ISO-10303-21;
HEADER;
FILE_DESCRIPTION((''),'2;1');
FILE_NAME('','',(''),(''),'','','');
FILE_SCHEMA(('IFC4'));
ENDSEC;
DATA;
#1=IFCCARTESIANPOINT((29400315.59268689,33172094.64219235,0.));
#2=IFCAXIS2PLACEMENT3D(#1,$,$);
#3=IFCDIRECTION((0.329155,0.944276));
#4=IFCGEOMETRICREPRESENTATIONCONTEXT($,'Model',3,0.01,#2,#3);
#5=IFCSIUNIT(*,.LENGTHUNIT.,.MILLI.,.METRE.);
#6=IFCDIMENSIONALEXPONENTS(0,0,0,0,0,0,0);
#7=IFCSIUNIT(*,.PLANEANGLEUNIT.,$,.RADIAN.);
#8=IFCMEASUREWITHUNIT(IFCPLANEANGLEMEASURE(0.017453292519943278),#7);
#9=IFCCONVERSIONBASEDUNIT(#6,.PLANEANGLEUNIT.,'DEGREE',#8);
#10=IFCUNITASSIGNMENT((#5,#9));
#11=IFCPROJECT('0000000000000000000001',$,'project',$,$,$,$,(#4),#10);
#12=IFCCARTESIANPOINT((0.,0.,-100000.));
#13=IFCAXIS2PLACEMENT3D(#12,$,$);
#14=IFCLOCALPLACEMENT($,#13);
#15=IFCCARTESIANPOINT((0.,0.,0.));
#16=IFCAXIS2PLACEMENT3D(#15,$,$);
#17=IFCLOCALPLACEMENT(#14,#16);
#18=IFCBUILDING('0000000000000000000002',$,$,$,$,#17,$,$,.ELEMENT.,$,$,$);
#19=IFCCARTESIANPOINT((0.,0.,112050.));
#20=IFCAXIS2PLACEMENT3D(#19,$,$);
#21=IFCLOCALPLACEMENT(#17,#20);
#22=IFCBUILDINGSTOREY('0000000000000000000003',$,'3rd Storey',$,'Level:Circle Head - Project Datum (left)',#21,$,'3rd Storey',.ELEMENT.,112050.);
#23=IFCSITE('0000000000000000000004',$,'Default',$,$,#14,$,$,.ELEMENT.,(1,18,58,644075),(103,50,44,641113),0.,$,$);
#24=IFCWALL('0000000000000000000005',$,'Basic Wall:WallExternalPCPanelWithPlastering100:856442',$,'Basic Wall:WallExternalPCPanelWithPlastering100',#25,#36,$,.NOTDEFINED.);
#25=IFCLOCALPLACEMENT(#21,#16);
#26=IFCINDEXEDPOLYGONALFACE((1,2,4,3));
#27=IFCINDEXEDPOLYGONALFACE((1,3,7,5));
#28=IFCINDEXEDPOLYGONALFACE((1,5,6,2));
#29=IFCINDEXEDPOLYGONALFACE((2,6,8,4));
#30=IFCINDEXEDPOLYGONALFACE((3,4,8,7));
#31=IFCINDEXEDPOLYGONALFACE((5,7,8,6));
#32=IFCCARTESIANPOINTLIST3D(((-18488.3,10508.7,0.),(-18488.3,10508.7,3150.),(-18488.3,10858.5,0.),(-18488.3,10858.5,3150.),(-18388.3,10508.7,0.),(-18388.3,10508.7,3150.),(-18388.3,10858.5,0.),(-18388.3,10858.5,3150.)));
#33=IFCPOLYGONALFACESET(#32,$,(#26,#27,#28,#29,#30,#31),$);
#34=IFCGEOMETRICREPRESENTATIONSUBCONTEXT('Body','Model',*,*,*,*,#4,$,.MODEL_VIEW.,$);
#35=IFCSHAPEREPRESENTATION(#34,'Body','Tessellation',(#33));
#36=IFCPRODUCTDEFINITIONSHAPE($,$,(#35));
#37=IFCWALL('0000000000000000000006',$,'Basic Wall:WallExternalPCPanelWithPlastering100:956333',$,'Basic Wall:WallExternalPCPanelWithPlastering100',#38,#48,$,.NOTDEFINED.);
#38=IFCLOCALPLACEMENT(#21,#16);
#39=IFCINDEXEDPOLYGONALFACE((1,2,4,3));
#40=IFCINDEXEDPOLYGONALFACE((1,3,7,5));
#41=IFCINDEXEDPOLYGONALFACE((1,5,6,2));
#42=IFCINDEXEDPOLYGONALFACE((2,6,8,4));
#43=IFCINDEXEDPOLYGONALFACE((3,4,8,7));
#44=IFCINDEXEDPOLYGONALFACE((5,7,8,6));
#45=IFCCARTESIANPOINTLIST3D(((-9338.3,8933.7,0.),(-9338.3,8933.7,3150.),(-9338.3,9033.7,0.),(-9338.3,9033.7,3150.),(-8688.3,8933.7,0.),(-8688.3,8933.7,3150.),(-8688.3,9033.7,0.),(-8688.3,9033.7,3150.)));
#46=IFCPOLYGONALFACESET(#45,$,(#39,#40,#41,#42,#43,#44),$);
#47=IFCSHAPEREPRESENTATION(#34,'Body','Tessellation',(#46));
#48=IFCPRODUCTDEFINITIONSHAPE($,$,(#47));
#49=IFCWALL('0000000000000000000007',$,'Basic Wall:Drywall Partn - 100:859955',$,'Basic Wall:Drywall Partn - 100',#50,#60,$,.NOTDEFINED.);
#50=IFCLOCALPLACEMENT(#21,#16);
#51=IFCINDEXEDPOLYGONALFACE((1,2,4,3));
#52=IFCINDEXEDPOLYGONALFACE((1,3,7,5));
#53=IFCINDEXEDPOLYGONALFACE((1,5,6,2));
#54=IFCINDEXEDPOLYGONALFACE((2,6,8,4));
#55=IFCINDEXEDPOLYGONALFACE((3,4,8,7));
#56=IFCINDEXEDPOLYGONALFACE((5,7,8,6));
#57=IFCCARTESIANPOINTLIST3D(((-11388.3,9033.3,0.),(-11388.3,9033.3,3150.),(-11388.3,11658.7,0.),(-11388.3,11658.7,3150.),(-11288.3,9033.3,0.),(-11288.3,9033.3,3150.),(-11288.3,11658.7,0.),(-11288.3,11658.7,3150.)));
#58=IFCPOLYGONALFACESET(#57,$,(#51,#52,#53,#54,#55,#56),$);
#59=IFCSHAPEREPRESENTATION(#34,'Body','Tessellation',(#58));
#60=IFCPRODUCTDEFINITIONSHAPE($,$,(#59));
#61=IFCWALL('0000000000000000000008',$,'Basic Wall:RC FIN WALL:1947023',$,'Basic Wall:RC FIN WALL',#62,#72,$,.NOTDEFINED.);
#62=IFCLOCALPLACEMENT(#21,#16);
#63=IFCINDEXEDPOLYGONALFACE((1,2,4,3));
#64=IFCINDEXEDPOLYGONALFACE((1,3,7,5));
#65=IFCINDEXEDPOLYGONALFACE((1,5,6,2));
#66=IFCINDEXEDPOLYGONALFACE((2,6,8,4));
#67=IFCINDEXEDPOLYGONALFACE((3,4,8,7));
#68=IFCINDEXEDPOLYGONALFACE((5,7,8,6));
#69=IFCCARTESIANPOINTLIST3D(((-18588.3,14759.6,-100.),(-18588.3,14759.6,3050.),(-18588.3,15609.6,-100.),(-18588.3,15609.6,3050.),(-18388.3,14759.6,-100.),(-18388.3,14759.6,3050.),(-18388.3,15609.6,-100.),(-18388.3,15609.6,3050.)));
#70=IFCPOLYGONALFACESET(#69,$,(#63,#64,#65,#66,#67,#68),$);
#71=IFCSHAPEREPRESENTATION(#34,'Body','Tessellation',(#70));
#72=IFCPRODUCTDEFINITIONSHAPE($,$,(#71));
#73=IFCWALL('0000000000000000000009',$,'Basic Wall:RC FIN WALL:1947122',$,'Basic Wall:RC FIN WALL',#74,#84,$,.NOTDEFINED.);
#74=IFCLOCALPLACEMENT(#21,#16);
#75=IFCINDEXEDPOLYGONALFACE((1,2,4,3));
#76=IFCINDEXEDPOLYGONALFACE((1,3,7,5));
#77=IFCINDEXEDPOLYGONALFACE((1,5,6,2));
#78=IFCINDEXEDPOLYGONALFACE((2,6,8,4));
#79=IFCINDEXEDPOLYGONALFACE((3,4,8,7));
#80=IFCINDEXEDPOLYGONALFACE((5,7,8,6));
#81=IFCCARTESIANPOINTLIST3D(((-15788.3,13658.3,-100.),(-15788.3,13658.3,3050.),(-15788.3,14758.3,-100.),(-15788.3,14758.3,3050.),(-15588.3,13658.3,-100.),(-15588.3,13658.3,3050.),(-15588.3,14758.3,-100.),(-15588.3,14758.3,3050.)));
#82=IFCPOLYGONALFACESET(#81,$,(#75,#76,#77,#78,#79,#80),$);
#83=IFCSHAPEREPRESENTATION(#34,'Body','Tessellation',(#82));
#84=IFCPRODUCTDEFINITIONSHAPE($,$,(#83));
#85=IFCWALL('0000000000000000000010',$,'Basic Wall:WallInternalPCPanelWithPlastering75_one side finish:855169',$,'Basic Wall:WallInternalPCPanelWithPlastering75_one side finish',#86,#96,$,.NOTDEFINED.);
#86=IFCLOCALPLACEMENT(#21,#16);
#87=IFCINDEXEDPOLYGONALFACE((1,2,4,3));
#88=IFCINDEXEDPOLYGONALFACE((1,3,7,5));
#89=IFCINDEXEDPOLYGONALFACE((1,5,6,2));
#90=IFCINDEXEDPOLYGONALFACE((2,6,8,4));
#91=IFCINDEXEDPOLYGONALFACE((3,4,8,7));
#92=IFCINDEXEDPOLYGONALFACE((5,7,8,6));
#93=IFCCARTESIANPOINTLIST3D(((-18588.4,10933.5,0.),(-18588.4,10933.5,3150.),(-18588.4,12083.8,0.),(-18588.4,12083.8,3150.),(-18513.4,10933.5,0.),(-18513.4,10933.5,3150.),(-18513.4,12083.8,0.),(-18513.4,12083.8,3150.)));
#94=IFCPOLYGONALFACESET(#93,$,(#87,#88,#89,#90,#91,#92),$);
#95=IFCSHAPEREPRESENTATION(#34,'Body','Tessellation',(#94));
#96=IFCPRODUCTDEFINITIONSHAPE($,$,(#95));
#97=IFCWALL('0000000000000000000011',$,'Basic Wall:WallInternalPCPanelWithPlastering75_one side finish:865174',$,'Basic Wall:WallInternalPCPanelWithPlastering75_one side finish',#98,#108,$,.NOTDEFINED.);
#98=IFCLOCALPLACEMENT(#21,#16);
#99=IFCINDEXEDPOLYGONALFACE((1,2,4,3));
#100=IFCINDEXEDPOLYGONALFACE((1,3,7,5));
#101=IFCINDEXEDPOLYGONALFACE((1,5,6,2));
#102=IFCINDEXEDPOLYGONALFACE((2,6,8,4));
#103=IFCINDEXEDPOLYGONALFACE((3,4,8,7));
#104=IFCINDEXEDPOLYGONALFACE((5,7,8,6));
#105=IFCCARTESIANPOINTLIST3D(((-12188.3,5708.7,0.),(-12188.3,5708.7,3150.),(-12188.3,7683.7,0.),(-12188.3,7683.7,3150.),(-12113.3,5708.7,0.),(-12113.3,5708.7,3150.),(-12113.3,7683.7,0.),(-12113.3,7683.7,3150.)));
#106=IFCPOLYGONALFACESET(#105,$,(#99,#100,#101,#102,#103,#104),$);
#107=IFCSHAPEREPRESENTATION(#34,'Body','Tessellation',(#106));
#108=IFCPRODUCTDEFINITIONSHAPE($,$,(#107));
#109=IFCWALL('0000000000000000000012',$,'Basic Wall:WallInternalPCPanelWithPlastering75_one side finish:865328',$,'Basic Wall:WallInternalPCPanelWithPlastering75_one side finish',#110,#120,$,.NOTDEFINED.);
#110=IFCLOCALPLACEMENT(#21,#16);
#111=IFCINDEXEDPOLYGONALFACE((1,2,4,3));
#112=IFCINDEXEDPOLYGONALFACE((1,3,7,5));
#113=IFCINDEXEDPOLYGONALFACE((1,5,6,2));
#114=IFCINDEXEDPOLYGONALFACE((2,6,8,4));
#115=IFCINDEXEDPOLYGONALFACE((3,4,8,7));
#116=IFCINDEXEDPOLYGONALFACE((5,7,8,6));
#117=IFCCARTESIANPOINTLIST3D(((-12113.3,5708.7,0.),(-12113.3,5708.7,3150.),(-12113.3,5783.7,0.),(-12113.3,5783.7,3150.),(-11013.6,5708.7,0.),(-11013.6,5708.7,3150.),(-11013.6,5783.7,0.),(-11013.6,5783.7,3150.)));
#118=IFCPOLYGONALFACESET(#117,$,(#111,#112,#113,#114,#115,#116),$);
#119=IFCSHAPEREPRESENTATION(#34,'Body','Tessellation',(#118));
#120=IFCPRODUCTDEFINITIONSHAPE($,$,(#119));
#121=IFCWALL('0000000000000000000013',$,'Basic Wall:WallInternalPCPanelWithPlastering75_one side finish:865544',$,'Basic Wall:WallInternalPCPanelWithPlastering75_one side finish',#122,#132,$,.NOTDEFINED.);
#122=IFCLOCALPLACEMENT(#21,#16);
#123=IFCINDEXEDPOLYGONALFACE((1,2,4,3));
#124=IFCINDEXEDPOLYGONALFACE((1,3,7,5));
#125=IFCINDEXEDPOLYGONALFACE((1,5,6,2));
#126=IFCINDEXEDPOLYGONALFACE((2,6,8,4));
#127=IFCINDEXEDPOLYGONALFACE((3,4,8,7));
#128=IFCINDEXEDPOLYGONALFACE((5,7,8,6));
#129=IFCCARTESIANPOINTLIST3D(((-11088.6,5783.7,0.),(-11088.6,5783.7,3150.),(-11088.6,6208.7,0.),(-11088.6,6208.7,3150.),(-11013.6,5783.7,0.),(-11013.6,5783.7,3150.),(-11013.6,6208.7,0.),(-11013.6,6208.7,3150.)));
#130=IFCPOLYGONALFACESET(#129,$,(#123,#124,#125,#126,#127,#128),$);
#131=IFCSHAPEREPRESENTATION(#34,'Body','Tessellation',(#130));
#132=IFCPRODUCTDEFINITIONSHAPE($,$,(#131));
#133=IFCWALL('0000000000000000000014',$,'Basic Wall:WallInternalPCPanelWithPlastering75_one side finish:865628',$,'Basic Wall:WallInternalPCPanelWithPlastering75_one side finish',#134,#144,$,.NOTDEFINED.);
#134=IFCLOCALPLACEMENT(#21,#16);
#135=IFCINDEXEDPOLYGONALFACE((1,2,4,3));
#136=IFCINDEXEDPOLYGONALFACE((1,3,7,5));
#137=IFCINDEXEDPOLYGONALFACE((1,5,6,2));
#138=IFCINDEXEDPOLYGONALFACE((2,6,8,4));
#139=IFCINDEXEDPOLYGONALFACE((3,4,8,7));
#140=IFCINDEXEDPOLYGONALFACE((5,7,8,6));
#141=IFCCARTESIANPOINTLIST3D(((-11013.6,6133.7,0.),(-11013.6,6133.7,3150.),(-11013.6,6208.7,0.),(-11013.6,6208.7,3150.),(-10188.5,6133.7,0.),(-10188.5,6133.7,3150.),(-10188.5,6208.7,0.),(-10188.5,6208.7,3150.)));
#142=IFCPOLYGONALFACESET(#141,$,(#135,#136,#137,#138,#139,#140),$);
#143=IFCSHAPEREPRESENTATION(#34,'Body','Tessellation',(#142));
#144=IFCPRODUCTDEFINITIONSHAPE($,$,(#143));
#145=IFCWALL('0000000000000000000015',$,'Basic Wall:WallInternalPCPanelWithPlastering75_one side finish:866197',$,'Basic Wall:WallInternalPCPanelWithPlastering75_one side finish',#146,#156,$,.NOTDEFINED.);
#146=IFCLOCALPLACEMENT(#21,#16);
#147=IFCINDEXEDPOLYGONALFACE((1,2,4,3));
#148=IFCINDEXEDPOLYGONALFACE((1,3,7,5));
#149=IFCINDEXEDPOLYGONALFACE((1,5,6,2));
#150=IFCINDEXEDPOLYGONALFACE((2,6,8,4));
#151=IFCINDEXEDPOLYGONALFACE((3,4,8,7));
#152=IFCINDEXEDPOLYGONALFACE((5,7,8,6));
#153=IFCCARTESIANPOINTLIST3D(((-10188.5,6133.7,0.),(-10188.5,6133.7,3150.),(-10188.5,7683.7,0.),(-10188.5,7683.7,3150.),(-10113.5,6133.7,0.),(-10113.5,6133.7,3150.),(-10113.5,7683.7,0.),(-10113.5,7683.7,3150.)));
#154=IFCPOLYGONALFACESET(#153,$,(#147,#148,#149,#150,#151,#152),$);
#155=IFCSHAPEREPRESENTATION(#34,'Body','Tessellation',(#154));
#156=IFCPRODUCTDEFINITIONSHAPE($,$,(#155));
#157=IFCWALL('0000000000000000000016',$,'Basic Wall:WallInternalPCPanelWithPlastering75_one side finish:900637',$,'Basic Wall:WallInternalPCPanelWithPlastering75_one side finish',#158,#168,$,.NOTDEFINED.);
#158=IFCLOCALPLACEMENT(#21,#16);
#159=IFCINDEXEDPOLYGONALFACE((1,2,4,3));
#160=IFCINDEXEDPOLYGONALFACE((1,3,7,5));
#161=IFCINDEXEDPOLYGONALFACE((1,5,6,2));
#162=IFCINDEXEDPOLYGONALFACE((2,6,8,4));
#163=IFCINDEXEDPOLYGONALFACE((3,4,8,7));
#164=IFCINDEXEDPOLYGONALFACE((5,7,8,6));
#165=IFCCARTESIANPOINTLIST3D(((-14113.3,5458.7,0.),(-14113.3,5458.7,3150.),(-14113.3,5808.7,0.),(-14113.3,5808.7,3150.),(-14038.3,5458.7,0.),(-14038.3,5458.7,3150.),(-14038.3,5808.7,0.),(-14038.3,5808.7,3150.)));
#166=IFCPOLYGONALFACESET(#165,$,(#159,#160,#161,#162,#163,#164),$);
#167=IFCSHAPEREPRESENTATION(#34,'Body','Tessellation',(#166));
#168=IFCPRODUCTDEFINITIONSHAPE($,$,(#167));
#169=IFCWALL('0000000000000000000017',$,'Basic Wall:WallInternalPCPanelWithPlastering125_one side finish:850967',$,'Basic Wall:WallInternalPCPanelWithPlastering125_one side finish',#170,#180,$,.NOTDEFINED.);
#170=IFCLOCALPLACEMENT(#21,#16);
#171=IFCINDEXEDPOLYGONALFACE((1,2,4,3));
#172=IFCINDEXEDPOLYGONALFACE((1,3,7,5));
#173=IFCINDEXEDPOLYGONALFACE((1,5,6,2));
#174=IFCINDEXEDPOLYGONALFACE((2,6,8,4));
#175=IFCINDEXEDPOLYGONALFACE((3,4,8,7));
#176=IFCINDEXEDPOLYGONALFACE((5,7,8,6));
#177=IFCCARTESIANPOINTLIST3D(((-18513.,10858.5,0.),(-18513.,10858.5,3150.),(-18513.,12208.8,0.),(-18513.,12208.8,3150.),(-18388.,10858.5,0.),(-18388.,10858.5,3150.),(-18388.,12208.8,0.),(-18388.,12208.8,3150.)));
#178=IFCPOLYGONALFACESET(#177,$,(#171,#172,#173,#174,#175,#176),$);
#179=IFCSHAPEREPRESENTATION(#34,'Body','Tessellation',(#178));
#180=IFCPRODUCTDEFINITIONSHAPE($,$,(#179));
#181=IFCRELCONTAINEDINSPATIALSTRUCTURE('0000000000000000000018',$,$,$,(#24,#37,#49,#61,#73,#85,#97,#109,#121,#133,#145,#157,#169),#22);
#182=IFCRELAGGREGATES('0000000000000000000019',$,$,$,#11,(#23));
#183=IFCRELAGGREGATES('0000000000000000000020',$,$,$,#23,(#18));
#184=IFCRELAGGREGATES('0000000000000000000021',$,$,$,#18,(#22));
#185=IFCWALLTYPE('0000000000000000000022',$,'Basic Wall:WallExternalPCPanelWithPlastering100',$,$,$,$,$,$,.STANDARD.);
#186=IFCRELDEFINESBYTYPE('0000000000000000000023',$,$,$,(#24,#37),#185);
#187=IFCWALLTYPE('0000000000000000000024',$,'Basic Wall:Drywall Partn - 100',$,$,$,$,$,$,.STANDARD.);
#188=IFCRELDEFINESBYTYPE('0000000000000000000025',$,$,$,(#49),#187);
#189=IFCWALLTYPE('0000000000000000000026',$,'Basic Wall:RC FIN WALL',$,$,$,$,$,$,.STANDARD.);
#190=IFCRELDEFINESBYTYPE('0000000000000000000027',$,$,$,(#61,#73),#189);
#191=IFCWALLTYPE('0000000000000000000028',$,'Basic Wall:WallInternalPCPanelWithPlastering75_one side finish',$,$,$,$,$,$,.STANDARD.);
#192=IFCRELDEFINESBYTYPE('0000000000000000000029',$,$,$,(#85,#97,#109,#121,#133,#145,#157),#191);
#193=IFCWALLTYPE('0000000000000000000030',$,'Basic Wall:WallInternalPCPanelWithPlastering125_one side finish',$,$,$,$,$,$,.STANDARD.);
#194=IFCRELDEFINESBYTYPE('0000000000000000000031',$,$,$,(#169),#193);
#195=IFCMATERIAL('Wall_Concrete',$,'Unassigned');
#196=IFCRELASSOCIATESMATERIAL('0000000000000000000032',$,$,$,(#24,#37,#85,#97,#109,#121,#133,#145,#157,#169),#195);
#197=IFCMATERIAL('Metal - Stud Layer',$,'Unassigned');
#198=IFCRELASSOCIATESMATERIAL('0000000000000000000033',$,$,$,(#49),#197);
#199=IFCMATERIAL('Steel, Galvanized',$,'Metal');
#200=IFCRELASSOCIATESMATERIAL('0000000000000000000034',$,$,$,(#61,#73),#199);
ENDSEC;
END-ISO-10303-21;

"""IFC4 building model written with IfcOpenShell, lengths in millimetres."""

from ifc_helpers import new_model, entity, si_unit, converted_unit, direction, frame, origin, place, context, subcontext, project, spatial, indexed_curve, outline, extrude, material, type_object, element, save


model = new_model("IFC4")

# Units and contexts
model_context = context("Model", 3, precision=0.01, world=frame((29400315.59268689, 33172094.64219235, 0.0)), true_north=direction((0.329155, 0.944276)))
body_context = subcontext(model_context, "Body", "Model", "MODEL_VIEW")
ifc_project = project(units=[si_unit("LENGTHUNIT", "METRE", prefix="MILLI"), converted_unit("PLANEANGLEUNIT", "DEGREE", entity("IfcPlaneAngleMeasure", 0.017453292519943278), si_unit("PLANEANGLEUNIT", "RADIAN"), dimensions=[0, 0, 0, 0, 0, 0, 0])], contexts=[model_context])

# Site, building, storey
site_placement = place(None, frame((0.0, 0.0, -100000.0)))
site = spatial("IfcSite", under=ifc_project, at=site_placement, Name="Default", CompositionType="ELEMENT", RefLatitude=(1, 18, 58, 644075), RefLongitude=(103, 50, 44, 641113), RefElevation=0.0)
building_placement = place(site_placement, origin())
building = spatial("IfcBuilding", under=site, at=building_placement, CompositionType="ELEMENT")
storey_placement = place(building_placement, frame((0.0, 0.0, 112050.0)))
storey = spatial("IfcBuildingStorey", under=building, at=storey_placement, Name="3rd Storey", ObjectType="Level:Circle Head - Project Datum (left)", LongName="3rd Storey", CompositionType="ELEMENT", Elevation=112050.0)

# Walls
ifc_material_1 = material(Name="Wall_Concrete", Category="Unassigned")
wall_type_1 = type_object("IfcWallType", Name="Basic Wall:WallExternalPCPanelWithPlastering100", PredefinedType="STANDARD")
wall_1_placement = place(storey_placement, frame((-18438.3, 10858.5, 0.0), z_axis=(0.0, 0.0, 1.0), x_axis=(0.0, -1.0, 0.0)))
element("IfcWall", 1, at=wall_1_placement, inside=storey, type_object=wall_type_1, material=ifc_material_1, Name="Basic Wall:WallExternalPCPanelWithPlastering100:856442", ObjectType="Basic Wall:WallExternalPCPanelWithPlastering100", PredefinedType="NOTDEFINED", context=body_context, shape_type="SweptSolid", body=[
    extrude(outline(indexed_curve([(349.8, 50.0), (0.0, 50.0), (0.0, -50.0), (349.8, -50.0), (349.8, 50.0)], self_intersect=False)), origin(), (0.0, 0.0, 1.0), 3150.0),
])
wall_2_placement = place(storey_placement, frame((-8688.3, 8983.7, 0.0), z_axis=(0.0, 0.0, 1.0), x_axis=(-1.0, 0.0, 0.0)))
element("IfcWall", 2, at=wall_2_placement, inside=storey, type_object=wall_type_1, material=ifc_material_1, Name="Basic Wall:WallExternalPCPanelWithPlastering100:956333", ObjectType="Basic Wall:WallExternalPCPanelWithPlastering100", PredefinedType="NOTDEFINED", context=body_context, shape_type="SweptSolid", body=[
    extrude(outline(indexed_curve([(650.0, 50.0), (0.0, 50.0), (0.0, -50.0), (650.0, -50.0), (650.0, 50.0)], self_intersect=False)), origin(), (0.0, 0.0, 1.0), 3150.0),
])
ifc_material_2 = material(Name="Metal - Stud Layer", Category="Unassigned")
wall_type_2 = type_object("IfcWallType", Name="Basic Wall:Drywall Partn - 100", PredefinedType="STANDARD")
wall_3_placement = place(storey_placement, frame((-11338.3, 11658.7, 0.0), z_axis=(0.0, 0.0, 1.0), x_axis=(0.0, -1.0, 0.0)))
element("IfcWall", 3, at=wall_3_placement, inside=storey, type_object=wall_type_2, material=ifc_material_2, Name="Basic Wall:Drywall Partn - 100:859955", ObjectType="Basic Wall:Drywall Partn - 100", PredefinedType="NOTDEFINED", context=body_context, shape_type="SweptSolid", body=[
    extrude(outline(indexed_curve([(2625.4, 50.0), (0.0, 50.0), (0.0, -50.0), (2625.4, -50.0), (2625.4, 50.0)], self_intersect=False)), origin(), (0.0, 0.0, 1.0), 3150.0),
])
ifc_material_3 = material(Name="Steel, Galvanized", Category="Metal")
wall_type_3 = type_object("IfcWallType", Name="Basic Wall:RC FIN WALL", PredefinedType="STANDARD")
wall_4_placement = place(storey_placement, frame((-18488.3, 14759.6, -100.0), z_axis=(0.0, 0.0, 1.0), x_axis=(0.0, 1.0, 0.0)))
element("IfcWall", 4, at=wall_4_placement, inside=storey, type_object=wall_type_3, material=ifc_material_3, Name="Basic Wall:RC FIN WALL:1947023", ObjectType="Basic Wall:RC FIN WALL", PredefinedType="NOTDEFINED", context=body_context, shape_type="SweptSolid", body=[
    extrude(outline(indexed_curve([(850.0, 100.0), (0.0, 100.0), (0.0, -100.0), (850.0, -100.0), (850.0, 100.0)], self_intersect=False)), origin(), (0.0, 0.0, 1.0), 3150.0),
])
wall_5_placement = place(storey_placement, frame((-15688.3, 13658.3, -100.0), z_axis=(0.0, 0.0, 1.0), x_axis=(0.0, 1.0, 0.0)))
element("IfcWall", 5, at=wall_5_placement, inside=storey, type_object=wall_type_3, material=ifc_material_3, Name="Basic Wall:RC FIN WALL:1947122", ObjectType="Basic Wall:RC FIN WALL", PredefinedType="NOTDEFINED", context=body_context, shape_type="SweptSolid", body=[
    extrude(outline(indexed_curve([(1100.0, 100.0), (0.0, 100.0), (0.0, -100.0), (1100.0, -100.0), (1100.0, 100.0)], self_intersect=False)), origin(), (0.0, 0.0, 1.0), 3150.0),
])
wall_type_4 = type_object("IfcWallType", Name="Basic Wall:WallInternalPCPanelWithPlastering75_one side finish", PredefinedType="STANDARD")
wall_6_placement = place(storey_placement, frame((-18550.9, 10933.5, 0.0), z_axis=(0.0, 0.0, 1.0), x_axis=(0.0, 1.0, 0.0)))
element("IfcWall", 6, at=wall_6_placement, inside=storey, type_object=wall_type_4, material=ifc_material_1, Name="Basic Wall:WallInternalPCPanelWithPlastering75_one side finish:855169", ObjectType="Basic Wall:WallInternalPCPanelWithPlastering75_one side finish", PredefinedType="NOTDEFINED", context=body_context, shape_type="SweptSolid", body=[
    extrude(outline(indexed_curve([(1150.3, 37.5), (0.0, 37.5), (0.0, -37.5), (1150.3, -37.5), (1150.3, 37.5)], self_intersect=False)), origin(), (0.0, 0.0, 1.0), 3150.0),
])
wall_7_placement = place(storey_placement, frame((-12150.8, 7683.7, 0.0), z_axis=(0.0, 0.0, 1.0), x_axis=(0.0, -1.0, 0.0)))
element("IfcWall", 7, at=wall_7_placement, inside=storey, type_object=wall_type_4, material=ifc_material_1, Name="Basic Wall:WallInternalPCPanelWithPlastering75_one side finish:865174", ObjectType="Basic Wall:WallInternalPCPanelWithPlastering75_one side finish", PredefinedType="NOTDEFINED", context=body_context, shape_type="SweptSolid", body=[
    extrude(outline(indexed_curve([(1975.0, 37.5), (0.0, 37.5), (0.0, -37.5), (1975.0, -37.5), (1975.0, 37.5)], self_intersect=False)), origin(), (0.0, 0.0, 1.0), 3150.0),
])
wall_8_placement = place(storey_placement, frame((-11013.6, 5746.2, 0.0), z_axis=(0.0, 0.0, 1.0), x_axis=(-1.0, 0.0, 0.0)))
element("IfcWall", 8, at=wall_8_placement, inside=storey, type_object=wall_type_4, material=ifc_material_1, Name="Basic Wall:WallInternalPCPanelWithPlastering75_one side finish:865328", ObjectType="Basic Wall:WallInternalPCPanelWithPlastering75_one side finish", PredefinedType="NOTDEFINED", context=body_context, shape_type="SweptSolid", body=[
    extrude(outline(indexed_curve([(1099.7, 37.5), (0.0, 37.5), (0.0, -37.5), (1099.7, -37.5), (1099.7, 37.5)], self_intersect=False)), origin(), (0.0, 0.0, 1.0), 3150.0),
])
wall_9_placement = place(storey_placement, frame((-11051.1, 5783.7, 0.0), z_axis=(0.0, 0.0, 1.0), x_axis=(0.0, 1.0, 0.0)))
element("IfcWall", 9, at=wall_9_placement, inside=storey, type_object=wall_type_4, material=ifc_material_1, Name="Basic Wall:WallInternalPCPanelWithPlastering75_one side finish:865544", ObjectType="Basic Wall:WallInternalPCPanelWithPlastering75_one side finish", PredefinedType="NOTDEFINED", context=body_context, shape_type="SweptSolid", body=[
    extrude(outline(indexed_curve([(425.0, 37.5), (0.0, 37.5), (0.0, -37.5), (425.0, -37.5), (425.0, 37.5)], self_intersect=False)), origin(), (0.0, 0.0, 1.0), 3150.0),
])
wall_10_placement = place(storey_placement, frame((-11013.6, 6171.2, 0.0)))
element("IfcWall", 10, at=wall_10_placement, inside=storey, type_object=wall_type_4, material=ifc_material_1, Name="Basic Wall:WallInternalPCPanelWithPlastering75_one side finish:865628", ObjectType="Basic Wall:WallInternalPCPanelWithPlastering75_one side finish", PredefinedType="NOTDEFINED", context=body_context, shape_type="SweptSolid", body=[
    extrude(outline(indexed_curve([(825.1, 37.5), (0.0, 37.5), (0.0, -37.5), (825.1, -37.5), (825.1, 37.5)], self_intersect=False)), origin(), (0.0, 0.0, 1.0), 3150.0),
])
wall_11_placement = place(storey_placement, frame((-10151.0, 6133.7, 0.0), z_axis=(0.0, 0.0, 1.0), x_axis=(0.0, 1.0, 0.0)))
element("IfcWall", 11, at=wall_11_placement, inside=storey, type_object=wall_type_4, material=ifc_material_1, Name="Basic Wall:WallInternalPCPanelWithPlastering75_one side finish:866197", ObjectType="Basic Wall:WallInternalPCPanelWithPlastering75_one side finish", PredefinedType="NOTDEFINED", context=body_context, shape_type="SweptSolid", body=[
    extrude(outline(indexed_curve([(1550.0, 37.5), (0.0, 37.5), (0.0, -37.5), (1550.0, -37.5), (1550.0, 37.5)], self_intersect=False)), origin(), (0.0, 0.0, 1.0), 3150.0),
])
wall_12_placement = place(storey_placement, frame((-14075.8, 5458.7, 0.0), z_axis=(0.0, 0.0, 1.0), x_axis=(0.0, 1.0, 0.0)))
element("IfcWall", 12, at=wall_12_placement, inside=storey, type_object=wall_type_4, material=ifc_material_1, Name="Basic Wall:WallInternalPCPanelWithPlastering75_one side finish:900637", ObjectType="Basic Wall:WallInternalPCPanelWithPlastering75_one side finish", PredefinedType="NOTDEFINED", context=body_context, shape_type="SweptSolid", body=[
    extrude(outline(indexed_curve([(350.0, 37.5), (0.0, 37.5), (0.0, -37.5), (350.0, -37.5), (350.0, 37.5)], self_intersect=False)), origin(), (0.0, 0.0, 1.0), 3150.0),
])
wall_type_5 = type_object("IfcWallType", Name="Basic Wall:WallInternalPCPanelWithPlastering125_one side finish", PredefinedType="STANDARD")
wall_13_placement = place(storey_placement, frame((-18450.5, 10858.5, 0.0), z_axis=(0.0, 0.0, 1.0), x_axis=(0.0, 1.0, 0.0)))
element("IfcWall", 13, at=wall_13_placement, inside=storey, type_object=wall_type_5, material=ifc_material_1, Name="Basic Wall:WallInternalPCPanelWithPlastering125_one side finish:850967", ObjectType="Basic Wall:WallInternalPCPanelWithPlastering125_one side finish", PredefinedType="NOTDEFINED", context=body_context, shape_type="SweptSolid", body=[
    extrude(outline(indexed_curve([(1350.3, 62.5), (0.0, 62.5), (0.0, -62.5), (1350.3, -62.5), (1350.3, 62.5)], self_intersect=False)), origin(), (0.0, 0.0, 1.0), 3150.0),
])

save(model, "model.ifc")
